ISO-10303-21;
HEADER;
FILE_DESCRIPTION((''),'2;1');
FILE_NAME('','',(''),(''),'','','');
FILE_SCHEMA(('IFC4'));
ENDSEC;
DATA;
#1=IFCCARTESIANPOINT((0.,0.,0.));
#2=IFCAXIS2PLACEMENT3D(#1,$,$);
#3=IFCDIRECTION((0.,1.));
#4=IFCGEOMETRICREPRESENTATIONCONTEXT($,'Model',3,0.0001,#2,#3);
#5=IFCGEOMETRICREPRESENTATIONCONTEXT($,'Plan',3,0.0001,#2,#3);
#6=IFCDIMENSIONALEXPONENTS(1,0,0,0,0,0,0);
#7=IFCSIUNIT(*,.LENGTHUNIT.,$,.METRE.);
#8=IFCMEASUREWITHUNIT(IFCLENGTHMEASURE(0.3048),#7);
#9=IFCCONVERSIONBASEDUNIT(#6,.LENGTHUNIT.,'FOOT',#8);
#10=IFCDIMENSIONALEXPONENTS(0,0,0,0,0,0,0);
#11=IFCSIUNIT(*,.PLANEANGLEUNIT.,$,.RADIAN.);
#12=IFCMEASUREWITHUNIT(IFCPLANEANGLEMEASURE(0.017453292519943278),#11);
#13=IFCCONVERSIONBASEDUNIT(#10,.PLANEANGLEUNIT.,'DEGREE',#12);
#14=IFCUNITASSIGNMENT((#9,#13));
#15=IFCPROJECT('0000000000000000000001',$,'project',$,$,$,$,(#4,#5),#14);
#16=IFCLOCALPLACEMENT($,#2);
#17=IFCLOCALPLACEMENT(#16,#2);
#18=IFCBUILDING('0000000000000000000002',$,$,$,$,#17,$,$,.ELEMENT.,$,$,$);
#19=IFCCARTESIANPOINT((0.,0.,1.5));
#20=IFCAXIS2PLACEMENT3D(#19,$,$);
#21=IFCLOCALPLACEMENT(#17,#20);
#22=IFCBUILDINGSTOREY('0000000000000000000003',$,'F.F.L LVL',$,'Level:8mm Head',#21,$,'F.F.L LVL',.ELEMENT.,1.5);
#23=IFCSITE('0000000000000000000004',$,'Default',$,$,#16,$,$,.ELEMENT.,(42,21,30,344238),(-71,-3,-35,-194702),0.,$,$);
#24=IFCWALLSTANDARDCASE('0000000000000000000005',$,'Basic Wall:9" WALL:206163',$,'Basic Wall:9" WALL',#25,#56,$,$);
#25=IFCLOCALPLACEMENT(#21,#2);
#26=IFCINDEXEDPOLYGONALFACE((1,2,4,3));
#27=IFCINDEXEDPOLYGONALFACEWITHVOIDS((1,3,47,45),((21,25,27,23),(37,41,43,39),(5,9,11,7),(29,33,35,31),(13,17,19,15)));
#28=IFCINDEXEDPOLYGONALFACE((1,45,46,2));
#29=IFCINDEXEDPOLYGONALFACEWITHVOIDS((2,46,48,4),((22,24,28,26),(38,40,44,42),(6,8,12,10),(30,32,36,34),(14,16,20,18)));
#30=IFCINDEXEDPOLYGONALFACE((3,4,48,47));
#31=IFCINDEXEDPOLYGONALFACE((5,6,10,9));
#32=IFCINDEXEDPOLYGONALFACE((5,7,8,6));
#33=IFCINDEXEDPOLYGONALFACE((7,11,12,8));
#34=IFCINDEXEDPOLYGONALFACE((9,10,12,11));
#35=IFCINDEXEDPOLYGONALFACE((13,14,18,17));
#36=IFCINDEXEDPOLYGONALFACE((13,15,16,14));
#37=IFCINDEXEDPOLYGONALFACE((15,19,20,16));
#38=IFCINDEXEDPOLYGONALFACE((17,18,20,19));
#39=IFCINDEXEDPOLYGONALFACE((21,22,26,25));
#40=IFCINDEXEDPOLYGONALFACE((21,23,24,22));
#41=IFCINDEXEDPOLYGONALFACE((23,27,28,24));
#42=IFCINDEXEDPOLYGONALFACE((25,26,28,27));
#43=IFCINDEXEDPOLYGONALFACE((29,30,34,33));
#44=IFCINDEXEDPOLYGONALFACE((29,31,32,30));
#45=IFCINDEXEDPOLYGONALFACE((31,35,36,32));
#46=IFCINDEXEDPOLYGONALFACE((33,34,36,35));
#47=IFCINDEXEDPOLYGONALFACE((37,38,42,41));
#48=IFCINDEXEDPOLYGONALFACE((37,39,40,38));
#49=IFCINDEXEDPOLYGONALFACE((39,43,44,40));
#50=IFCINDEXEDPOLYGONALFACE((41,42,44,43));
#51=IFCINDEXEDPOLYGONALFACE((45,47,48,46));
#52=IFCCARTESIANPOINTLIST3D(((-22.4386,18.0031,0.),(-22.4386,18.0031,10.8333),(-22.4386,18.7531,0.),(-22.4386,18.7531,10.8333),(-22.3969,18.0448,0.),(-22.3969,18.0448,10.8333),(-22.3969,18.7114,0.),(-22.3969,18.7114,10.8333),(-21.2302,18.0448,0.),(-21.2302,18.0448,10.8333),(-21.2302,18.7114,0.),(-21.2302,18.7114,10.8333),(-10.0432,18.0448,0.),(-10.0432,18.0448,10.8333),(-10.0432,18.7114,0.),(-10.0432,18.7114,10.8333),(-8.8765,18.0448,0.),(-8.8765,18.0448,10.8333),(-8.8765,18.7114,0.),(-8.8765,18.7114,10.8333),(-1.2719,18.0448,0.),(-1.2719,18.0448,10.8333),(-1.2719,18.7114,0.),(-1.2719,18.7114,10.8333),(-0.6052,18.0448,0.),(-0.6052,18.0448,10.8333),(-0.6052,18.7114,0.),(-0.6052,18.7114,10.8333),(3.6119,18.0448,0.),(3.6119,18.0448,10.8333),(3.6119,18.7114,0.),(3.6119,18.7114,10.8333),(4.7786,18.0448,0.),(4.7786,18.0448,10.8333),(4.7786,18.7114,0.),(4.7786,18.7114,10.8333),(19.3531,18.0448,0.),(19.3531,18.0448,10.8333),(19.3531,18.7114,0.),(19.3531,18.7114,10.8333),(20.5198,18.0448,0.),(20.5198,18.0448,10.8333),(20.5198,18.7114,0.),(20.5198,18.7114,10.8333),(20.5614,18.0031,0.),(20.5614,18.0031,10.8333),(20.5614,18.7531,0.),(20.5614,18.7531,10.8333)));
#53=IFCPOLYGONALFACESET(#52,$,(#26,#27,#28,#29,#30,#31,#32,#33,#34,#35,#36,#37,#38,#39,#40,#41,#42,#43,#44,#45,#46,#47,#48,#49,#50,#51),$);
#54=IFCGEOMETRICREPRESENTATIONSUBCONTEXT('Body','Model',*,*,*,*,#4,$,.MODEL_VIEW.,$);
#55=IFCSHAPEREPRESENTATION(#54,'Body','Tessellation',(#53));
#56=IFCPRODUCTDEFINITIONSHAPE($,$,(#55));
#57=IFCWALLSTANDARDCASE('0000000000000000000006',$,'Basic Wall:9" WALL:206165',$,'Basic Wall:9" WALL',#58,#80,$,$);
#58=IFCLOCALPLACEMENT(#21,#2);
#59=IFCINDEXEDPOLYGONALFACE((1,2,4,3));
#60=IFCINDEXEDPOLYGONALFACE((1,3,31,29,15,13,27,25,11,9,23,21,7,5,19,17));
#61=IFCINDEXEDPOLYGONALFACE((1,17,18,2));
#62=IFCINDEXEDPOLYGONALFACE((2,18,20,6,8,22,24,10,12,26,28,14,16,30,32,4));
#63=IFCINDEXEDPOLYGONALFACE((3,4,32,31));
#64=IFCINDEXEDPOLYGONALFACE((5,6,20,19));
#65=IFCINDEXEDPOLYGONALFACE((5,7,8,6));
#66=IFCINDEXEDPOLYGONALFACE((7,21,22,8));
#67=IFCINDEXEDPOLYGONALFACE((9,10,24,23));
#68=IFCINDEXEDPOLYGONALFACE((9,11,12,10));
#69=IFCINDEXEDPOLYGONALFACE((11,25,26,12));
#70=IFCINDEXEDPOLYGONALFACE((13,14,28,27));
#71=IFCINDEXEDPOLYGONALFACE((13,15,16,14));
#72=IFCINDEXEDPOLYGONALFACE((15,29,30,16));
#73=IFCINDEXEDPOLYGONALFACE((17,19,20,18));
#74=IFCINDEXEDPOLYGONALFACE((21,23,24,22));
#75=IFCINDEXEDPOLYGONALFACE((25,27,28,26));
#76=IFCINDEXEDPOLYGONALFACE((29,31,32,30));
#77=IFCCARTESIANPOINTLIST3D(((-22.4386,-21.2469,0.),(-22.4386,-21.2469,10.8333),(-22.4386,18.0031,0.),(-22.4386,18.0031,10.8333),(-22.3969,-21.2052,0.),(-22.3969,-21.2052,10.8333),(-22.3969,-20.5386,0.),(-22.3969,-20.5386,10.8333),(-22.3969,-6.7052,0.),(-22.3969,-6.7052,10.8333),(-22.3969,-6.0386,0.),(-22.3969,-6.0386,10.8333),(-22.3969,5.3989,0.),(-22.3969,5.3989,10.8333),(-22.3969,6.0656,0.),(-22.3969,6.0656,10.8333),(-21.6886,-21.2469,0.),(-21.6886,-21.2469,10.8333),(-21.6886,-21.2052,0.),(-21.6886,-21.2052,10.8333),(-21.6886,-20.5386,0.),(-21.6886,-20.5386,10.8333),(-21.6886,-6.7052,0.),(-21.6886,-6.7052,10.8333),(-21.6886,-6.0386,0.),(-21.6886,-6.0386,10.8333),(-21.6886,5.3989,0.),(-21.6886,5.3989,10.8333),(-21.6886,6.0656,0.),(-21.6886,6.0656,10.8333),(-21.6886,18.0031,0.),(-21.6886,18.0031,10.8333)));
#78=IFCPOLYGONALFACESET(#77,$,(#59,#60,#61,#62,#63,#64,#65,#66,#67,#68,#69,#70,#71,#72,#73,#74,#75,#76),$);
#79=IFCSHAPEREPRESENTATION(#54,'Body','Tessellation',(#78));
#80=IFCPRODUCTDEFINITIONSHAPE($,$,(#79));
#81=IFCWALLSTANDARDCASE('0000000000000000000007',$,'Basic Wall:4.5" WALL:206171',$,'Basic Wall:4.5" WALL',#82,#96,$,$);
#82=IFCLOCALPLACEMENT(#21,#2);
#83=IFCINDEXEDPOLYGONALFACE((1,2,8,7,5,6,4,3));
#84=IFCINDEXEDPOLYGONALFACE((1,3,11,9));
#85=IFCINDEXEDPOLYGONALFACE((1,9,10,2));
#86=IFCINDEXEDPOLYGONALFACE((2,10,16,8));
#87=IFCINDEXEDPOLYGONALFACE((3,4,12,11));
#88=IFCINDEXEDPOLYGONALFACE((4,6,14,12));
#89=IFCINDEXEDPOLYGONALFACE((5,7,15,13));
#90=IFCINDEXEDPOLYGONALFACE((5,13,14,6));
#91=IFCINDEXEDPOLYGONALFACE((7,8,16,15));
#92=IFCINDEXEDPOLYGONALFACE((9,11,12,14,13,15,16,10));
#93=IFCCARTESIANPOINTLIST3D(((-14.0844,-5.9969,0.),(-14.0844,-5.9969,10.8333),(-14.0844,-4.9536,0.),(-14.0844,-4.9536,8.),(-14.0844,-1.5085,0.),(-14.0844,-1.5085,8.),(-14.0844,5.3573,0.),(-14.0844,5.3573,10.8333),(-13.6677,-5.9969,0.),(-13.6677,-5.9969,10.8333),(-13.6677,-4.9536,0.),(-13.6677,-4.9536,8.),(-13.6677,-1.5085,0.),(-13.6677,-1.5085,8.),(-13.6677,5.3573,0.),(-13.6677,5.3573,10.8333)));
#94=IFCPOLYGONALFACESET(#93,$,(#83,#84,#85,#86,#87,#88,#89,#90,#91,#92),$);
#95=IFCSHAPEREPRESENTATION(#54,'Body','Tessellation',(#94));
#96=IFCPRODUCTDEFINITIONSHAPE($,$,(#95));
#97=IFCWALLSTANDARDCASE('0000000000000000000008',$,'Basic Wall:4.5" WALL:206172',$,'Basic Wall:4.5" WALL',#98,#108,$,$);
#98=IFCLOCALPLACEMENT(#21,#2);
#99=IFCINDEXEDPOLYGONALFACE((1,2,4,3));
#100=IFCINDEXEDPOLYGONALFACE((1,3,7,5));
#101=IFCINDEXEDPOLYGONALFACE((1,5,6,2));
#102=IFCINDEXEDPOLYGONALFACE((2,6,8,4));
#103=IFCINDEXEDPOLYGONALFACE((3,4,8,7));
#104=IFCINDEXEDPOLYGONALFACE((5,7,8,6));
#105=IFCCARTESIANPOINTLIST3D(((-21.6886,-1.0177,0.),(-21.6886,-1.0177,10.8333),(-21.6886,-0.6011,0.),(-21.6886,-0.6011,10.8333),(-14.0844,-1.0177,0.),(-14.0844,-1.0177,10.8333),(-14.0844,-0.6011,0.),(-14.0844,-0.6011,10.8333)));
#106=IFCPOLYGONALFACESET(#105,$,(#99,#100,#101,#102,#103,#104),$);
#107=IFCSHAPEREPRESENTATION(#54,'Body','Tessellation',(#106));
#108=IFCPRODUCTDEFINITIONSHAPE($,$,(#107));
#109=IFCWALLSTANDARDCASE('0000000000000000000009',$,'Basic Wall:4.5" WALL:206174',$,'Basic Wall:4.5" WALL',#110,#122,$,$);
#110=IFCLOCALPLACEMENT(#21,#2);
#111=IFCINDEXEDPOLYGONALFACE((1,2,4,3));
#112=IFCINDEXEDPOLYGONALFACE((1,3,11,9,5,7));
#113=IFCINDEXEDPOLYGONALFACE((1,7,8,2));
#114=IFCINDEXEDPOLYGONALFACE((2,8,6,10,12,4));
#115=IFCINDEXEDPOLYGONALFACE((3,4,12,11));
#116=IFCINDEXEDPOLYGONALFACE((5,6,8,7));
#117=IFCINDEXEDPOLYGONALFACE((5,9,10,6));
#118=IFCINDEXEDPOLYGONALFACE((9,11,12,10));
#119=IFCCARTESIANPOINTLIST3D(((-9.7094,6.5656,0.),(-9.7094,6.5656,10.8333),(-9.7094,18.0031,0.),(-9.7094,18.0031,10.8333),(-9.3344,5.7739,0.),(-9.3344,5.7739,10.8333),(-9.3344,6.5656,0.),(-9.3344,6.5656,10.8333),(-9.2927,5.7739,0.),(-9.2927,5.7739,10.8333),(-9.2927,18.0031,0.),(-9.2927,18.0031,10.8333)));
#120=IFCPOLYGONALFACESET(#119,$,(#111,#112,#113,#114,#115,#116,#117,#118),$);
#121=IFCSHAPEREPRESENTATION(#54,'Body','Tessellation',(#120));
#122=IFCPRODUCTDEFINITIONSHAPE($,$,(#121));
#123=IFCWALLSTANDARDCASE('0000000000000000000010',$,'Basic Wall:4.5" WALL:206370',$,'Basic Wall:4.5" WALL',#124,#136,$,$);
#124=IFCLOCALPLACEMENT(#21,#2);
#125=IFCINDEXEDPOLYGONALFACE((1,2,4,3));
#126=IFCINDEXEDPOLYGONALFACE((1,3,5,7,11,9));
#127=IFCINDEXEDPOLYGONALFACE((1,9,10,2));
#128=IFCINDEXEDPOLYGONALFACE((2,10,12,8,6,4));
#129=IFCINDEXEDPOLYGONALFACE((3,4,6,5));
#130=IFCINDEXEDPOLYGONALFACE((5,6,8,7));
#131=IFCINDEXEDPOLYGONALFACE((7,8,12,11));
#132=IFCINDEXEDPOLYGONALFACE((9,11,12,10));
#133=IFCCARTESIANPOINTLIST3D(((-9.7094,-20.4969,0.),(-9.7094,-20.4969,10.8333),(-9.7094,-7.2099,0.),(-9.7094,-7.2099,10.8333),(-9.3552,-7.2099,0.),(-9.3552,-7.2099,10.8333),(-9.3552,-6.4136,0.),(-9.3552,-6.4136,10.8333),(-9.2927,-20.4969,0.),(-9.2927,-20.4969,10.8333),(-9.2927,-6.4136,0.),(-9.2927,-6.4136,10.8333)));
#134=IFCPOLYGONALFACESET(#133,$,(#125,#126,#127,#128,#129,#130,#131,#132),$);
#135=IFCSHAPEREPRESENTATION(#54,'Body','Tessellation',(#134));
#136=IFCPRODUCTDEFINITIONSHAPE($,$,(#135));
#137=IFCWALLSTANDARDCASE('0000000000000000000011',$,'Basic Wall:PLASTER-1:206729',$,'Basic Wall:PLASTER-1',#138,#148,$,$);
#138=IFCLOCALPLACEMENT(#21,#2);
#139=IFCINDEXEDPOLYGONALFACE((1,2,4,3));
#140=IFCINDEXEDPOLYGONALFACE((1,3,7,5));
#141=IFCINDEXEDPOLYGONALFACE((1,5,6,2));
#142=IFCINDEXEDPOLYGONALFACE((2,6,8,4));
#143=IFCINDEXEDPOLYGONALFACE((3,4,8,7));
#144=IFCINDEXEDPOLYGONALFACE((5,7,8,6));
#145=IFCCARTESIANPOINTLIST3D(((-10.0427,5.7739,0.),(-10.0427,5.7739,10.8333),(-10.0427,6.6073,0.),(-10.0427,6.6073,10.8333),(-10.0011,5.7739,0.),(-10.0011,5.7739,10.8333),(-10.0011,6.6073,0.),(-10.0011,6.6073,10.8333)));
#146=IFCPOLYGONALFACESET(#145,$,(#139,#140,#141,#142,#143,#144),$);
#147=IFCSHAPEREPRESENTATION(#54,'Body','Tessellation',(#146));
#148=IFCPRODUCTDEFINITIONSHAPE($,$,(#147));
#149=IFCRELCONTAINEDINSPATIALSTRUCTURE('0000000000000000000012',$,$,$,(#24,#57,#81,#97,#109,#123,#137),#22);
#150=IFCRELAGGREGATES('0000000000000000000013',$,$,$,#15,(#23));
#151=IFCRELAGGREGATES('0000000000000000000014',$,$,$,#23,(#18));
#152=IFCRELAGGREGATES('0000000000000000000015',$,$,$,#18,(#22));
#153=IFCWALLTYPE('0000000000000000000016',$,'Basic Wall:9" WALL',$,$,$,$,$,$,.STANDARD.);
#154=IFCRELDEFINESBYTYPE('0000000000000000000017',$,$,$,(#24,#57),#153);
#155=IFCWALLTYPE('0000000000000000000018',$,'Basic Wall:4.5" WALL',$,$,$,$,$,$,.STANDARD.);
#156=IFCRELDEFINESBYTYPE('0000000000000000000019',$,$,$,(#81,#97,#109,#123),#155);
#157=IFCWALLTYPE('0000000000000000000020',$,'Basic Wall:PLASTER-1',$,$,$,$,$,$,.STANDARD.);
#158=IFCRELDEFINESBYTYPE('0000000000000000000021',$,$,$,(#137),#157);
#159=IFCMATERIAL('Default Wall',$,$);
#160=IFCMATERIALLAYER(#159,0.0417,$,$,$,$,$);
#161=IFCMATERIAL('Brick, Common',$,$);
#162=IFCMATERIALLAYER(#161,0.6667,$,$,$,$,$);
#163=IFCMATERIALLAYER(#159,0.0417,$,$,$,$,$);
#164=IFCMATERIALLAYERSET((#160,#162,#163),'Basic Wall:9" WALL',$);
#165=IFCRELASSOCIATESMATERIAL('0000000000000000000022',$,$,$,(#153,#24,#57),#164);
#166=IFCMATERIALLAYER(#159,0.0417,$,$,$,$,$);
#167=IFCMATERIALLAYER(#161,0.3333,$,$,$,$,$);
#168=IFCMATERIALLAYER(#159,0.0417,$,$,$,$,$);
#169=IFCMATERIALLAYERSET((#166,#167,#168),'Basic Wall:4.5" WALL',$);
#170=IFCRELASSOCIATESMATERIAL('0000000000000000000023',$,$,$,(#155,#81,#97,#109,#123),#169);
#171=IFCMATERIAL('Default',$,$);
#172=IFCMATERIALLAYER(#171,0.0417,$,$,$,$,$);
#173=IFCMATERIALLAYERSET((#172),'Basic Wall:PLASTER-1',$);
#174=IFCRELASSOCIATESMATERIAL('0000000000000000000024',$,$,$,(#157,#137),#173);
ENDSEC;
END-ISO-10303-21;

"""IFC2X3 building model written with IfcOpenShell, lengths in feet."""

from ifc_helpers import new_model, entity, si_unit, converted_unit, direction, frame, frame_2d, origin, origin_2d_with_axis, place, context, subcontext, project, spatial, polyline, rectangle, extrude, clip, bounded_halfspace, material, layer, layer_set, layer_usage, type_object, element, save


model = new_model("IFC2X3")

# Units and contexts
model_context = context("Model", 3, precision=0.0001, world=origin(), true_north=direction((0.0, 1.0)))
plan_context = context("Plan", 3, precision=0.0001, world=origin(), true_north=direction((0.0, 1.0)))
body_context = subcontext(model_context, "Body", "Model", "MODEL_VIEW")
ifc_project = project(units=[converted_unit("LENGTHUNIT", "FOOT", entity("IfcLengthMeasure", 0.3048), si_unit("LENGTHUNIT", "METRE"), dimensions=[1, 0, 0, 0, 0, 0, 0]), converted_unit("PLANEANGLEUNIT", "DEGREE", entity("IfcPlaneAngleMeasure", 0.017453292519943278), si_unit("PLANEANGLEUNIT", "RADIAN"), dimensions=[0, 0, 0, 0, 0, 0, 0])], contexts=[model_context, plan_context])

# Site, building, storey
site_placement = place(None, origin())
site = spatial("IfcSite", under=ifc_project, at=site_placement, Name="Default", CompositionType="ELEMENT", RefLatitude=(42, 21, 30, 344238), RefLongitude=(-71, -3, -35, -194702), RefElevation=0.0)
building_placement = place(site_placement, origin())
building = spatial("IfcBuilding", under=site, at=building_placement, CompositionType="ELEMENT")
storey_placement = place(building_placement, frame((0.0, 0.0, 1.5)))
storey = spatial("IfcBuildingStorey", under=building, at=storey_placement, Name="F.F.L LVL", ObjectType="Level:8mm Head", LongName="F.F.L LVL", CompositionType="ELEMENT", Elevation=1.5)

# Wall, openings
ifc_material_1 = material(Name="Default Wall")
ifc_layer_1 = layer(ifc_material_1, 0.0417)
ifc_material_2 = material(Name="Brick, Common")
ifc_layer_2 = layer(ifc_material_2, 0.6667)
ifc_layer_3 = layer(ifc_material_1, 0.0417)
ifc_layer_set_1 = layer_set([ifc_layer_1, ifc_layer_2, ifc_layer_3], Name="Basic Wall:9\" WALL")
ifc_layer_usage_1 = layer_usage(ifc_layer_set_1, "AXIS2", "NEGATIVE", 0.375)
wall_type_1 = type_object("IfcWallType", Name="Basic Wall:9\" WALL", PredefinedType="STANDARD", material=ifc_layer_set_1)
wall_1_placement = place(storey_placement, frame((-22.4386, 18.3781, 0.0)))
wall_1 = element("IfcWallStandardCase", 1, at=wall_1_placement, inside=storey, type_object=wall_type_1, material=ifc_layer_usage_1, Name="Basic Wall:9\" WALL:206163", ObjectType="Basic Wall:9\" WALL", context=body_context, shape_type="SweptSolid", body=[
    extrude(rectangle(XDim=43.0, YDim=0.75, at=frame_2d((21.5, 0.0), x_axis=(-1.0, 0.0))), origin(), (0.0, 0.0, 1.0), 10.8333),
])
opening_1_placement = place(storey_placement, frame((-22.4386, 18.3781, 0.0)))
element("IfcOpeningElement", 2, at=opening_1_placement, cuts=wall_1, ObjectType="Opening", context=body_context, shape_type="SweptSolid", body=[
    extrude(rectangle(XDim=10.8333, YDim=0.6667, at=frame_2d((0.0, 0.0), x_axis=(1.0, 0.0))), frame((41.7917, 0.0, 5.4167), z_axis=(1.0, 0.0, 0.0), x_axis=(0.0, 0.0, -1.0)), (0.0, 0.0, 1.0), 1.1667),
])
opening_2_placement = place(storey_placement, frame((-22.4386, 18.3781, 0.0)))
element("IfcOpeningElement", 3, at=opening_2_placement, cuts=wall_1, ObjectType="Opening", context=body_context, shape_type="SweptSolid", body=[
    extrude(rectangle(XDim=10.8333, YDim=0.6667, at=origin_2d_with_axis()), frame((21.1667, 0.0, 5.4167), z_axis=(1.0, 0.0, 0.0), x_axis=(0.0, 0.0, 1.0)), (0.0, 0.0, 1.0), 0.6667),
])
opening_3_placement = place(storey_placement, frame((-22.4386, 18.3781, 0.0)))
element("IfcOpeningElement", 4, at=opening_3_placement, cuts=wall_1, ObjectType="Opening", context=body_context, shape_type="SweptSolid", body=[
    extrude(rectangle(XDim=10.8333, YDim=0.6667, at=origin_2d_with_axis()), frame((26.0505, 0.0, 5.4167), z_axis=(1.0, 0.0, 0.0), x_axis=(0.0, 0.0, -1.0)), (0.0, 0.0, 1.0), 1.1667),
])
opening_4_placement = place(storey_placement, frame((-22.4386, 18.3781, 0.0)))
element("IfcOpeningElement", 5, at=opening_4_placement, cuts=wall_1, ObjectType="Opening", context=body_context, shape_type="SweptSolid", body=[
    extrude(rectangle(XDim=10.8333, YDim=0.6667, at=origin_2d_with_axis()), frame((12.3954, 0.0, 5.4167), z_axis=(1.0, 0.0, 0.0), x_axis=(0.0, 0.0, -1.0)), (0.0, 0.0, 1.0), 1.1667),
])
opening_5_placement = place(storey_placement, frame((-22.4386, 18.3781, 0.0)))
element("IfcOpeningElement", 6, at=opening_5_placement, cuts=wall_1, ObjectType="Opening", context=body_context, shape_type="SweptSolid", body=[
    extrude(rectangle(XDim=10.8333, YDim=0.6667, at=origin_2d_with_axis()), frame((0.0417, 0.0, 5.4167), z_axis=(1.0, 0.0, 0.0), x_axis=(0.0, 0.0, -1.0)), (0.0, 0.0, 1.0), 1.1667),
])

# Wall
ifc_layer_usage_2 = layer_usage(ifc_layer_set_1, "AXIS2", "NEGATIVE", 0.375)
wall_2_placement = place(storey_placement, frame((-22.0636, 18.0031, 0.0), z_axis=(0.0, 0.0, 1.0), x_axis=(0.0, -1.0, 0.0)))
element("IfcWallStandardCase", 7, at=wall_2_placement, inside=storey, type_object=wall_type_1, material=ifc_layer_usage_2, Name="Basic Wall:9\" WALL:206165", ObjectType="Basic Wall:9\" WALL", context=body_context, shape_type="Clipping", body=[
    clip(clip(clip(extrude(rectangle(XDim=39.25, YDim=0.75, at=frame_2d((19.625, 0.0), x_axis=(-1.0, 0.0))), origin(), (0.0, 0.0, 1.0), 10.8333), bounded_halfspace(frame((39.2083, -0.3333, 10.8333), z_axis=(0.0, -1.0, 0.0), x_axis=(0.0, 0.0, -1.0)), True, frame((39.2083, -0.3333, 10.8333), z_axis=(0.0, -1.0, 0.0), x_axis=(0.0, 0.0, -1.0)), polyline([(0.0, 0.0), (0.0, -0.6667), (10.8333, -0.6667), (10.8333, 0.0), (0.0, 0.0)]))), bounded_halfspace(frame((24.7083, -0.3333, 10.8333), z_axis=(0.0, -1.0, 0.0), x_axis=(0.0, 0.0, -1.0)), True, frame((24.7083, -0.3333, 10.8333), z_axis=(0.0, -1.0, 0.0), x_axis=(0.0, 0.0, -1.0)), polyline([(0.0, 0.0), (0.0, -0.6667), (10.8333, -0.6667), (10.8333, 0.0), (0.0, 0.0)]))), bounded_halfspace(frame((12.6042, -0.3333, 10.8333), z_axis=(0.0, -1.0, 0.0), x_axis=(0.0, 0.0, -1.0)), True, frame((12.6042, -0.3333, 10.8333), z_axis=(0.0, -1.0, 0.0), x_axis=(0.0, 0.0, -1.0)), polyline([(0.0, 0.0), (0.0, -0.6667), (10.8333, -0.6667), (10.8333, 0.0), (0.0, 0.0)]))),
])

# Wall, opening
ifc_layer_4 = layer(ifc_material_1, 0.0417)
ifc_layer_5 = layer(ifc_material_2, 0.3333)
ifc_layer_6 = layer(ifc_material_1, 0.0417)
ifc_layer_set_2 = layer_set([ifc_layer_4, ifc_layer_5, ifc_layer_6], Name="Basic Wall:4.5\" WALL")
ifc_layer_usage_3 = layer_usage(ifc_layer_set_2, "AXIS2", "NEGATIVE", 0.2083)
wall_type_2 = type_object("IfcWallType", Name="Basic Wall:4.5\" WALL", PredefinedType="STANDARD", material=ifc_layer_set_2)
wall_3_placement = place(storey_placement, frame((-13.8761, 5.3573, 0.0), z_axis=(0.0, 0.0, 1.0), x_axis=(0.0, -1.0, 0.0)))
wall_3 = element("IfcWallStandardCase", 8, at=wall_3_placement, inside=storey, type_object=wall_type_2, material=ifc_layer_usage_3, Name="Basic Wall:4.5\" WALL:206171", ObjectType="Basic Wall:4.5\" WALL", context=body_context, shape_type="SweptSolid", body=[
    extrude(rectangle(XDim=11.3542, YDim=0.4167, at=frame_2d((5.6771, 0.0), x_axis=(-1.0, 0.0))), origin(), (0.0, 0.0, 1.0), 10.8333),
])
opening_6_placement = place(wall_3_placement, origin())
element("IfcOpeningElement", 9, at=opening_6_placement, cuts=wall_3, ObjectType="Opening", context=body_context, shape_type="SweptSolid", body=[
    extrude(rectangle(XDim=8.0, YDim=3.4451, at=origin_2d_with_axis()), frame((8.5884, -0.2083, 4.0), z_axis=(0.0, 1.0, 0.0), x_axis=(0.0, 0.0, -1.0)), (0.0, 0.0, 1.0), 0.4167),
])

# Wall
ifc_layer_usage_4 = layer_usage(ifc_layer_set_2, "AXIS2", "NEGATIVE", 0.2083)
wall_4_placement = place(storey_placement, frame((-14.0844, -0.8094, 0.0), z_axis=(0.0, 0.0, 1.0), x_axis=(-1.0, 0.0, 0.0)))
element("IfcWallStandardCase", 10, at=wall_4_placement, inside=storey, type_object=wall_type_2, material=ifc_layer_usage_4, Name="Basic Wall:4.5\" WALL:206172", ObjectType="Basic Wall:4.5\" WALL", context=body_context, shape_type="SweptSolid", body=[
    extrude(rectangle(XDim=7.6042, YDim=0.4167, at=frame_2d((3.8021, 0.0), x_axis=(-1.0, 0.0))), origin(), (0.0, 0.0, 1.0), 10.8333),
])

# Walls
ifc_layer_usage_5 = layer_usage(ifc_layer_set_2, "AXIS2", "NEGATIVE", 0.2083)
wall_5_placement = place(storey_placement, frame((-9.5011, 18.0031, 0.0), z_axis=(0.0, 0.0, 1.0), x_axis=(0.0, -1.0, 0.0)))
element("IfcWallStandardCase", 11, at=wall_5_placement, inside=storey, type_object=wall_type_2, material=ifc_layer_usage_5, Name="Basic Wall:4.5\" WALL:206174", ObjectType="Basic Wall:4.5\" WALL", context=body_context, shape_type="Clipping", body=[
    clip(clip(extrude(rectangle(XDim=12.2292, YDim=0.4167, at=frame_2d((6.1146, 0.0), x_axis=(-1.0, 0.0))), origin(), (0.0, 0.0, 1.0), 10.8333), bounded_halfspace(frame((11.4375, 0.1667, 0.0), z_axis=(-1.0, 0.0, 0.0), x_axis=(0.0, 0.0, -1.0)), True, frame((11.4375, 0.1667, 0.0), z_axis=(-1.0, 0.0, 0.0), x_axis=(0.0, 0.0, -1.0)), polyline([(0.0, 0.0), (0.0, 0.375), (-10.8333, 0.375), (-10.8333, 0.0), (0.0, 0.0)]))), bounded_halfspace(frame((11.4375, 0.1667, 10.8333), z_axis=(0.0, 1.0, 0.0), x_axis=(0.0, 0.0, -1.0)), True, frame((11.4375, 0.1667, 10.8333), z_axis=(0.0, 1.0, 0.0), x_axis=(0.0, 0.0, -1.0)), polyline([(0.0, 0.0), (0.0, -0.7917), (10.8333, -0.7917), (10.8333, 0.0), (0.0, 0.0)]))),
])
ifc_layer_usage_6 = layer_usage(ifc_layer_set_2, "AXIS2", "NEGATIVE", 0.2083)
wall_6_placement = place(storey_placement, frame((-9.5011, -20.4969, 0.0), z_axis=(0.0, 0.0, 1.0), x_axis=(0.0, 1.0, 0.0)))
element("IfcWallStandardCase", 12, at=wall_6_placement, inside=storey, type_object=wall_type_2, material=ifc_layer_usage_6, Name="Basic Wall:4.5\" WALL:206370", ObjectType="Basic Wall:4.5\" WALL", context=body_context, shape_type="Clipping", body=[
    clip(clip(extrude(rectangle(XDim=14.0833, YDim=0.4167, at=frame_2d((7.0417, 0.0), x_axis=(-1.0, 0.0))), origin(), (0.0, 0.0, 1.0), 10.8333), bounded_halfspace(frame((13.287, -0.1458, 0.0), z_axis=(0.0, -1.0, 0.0), x_axis=(0.0, 0.0, -1.0)), True, frame((13.287, -0.1458, 0.0), z_axis=(0.0, -1.0, 0.0), x_axis=(0.0, 0.0, -1.0)), polyline([(0.0, 0.0), (0.0, 0.7963), (-10.8333, 0.7963), (-10.8333, 0.0), (0.0, 0.0)]))), bounded_halfspace(frame((13.287, -0.1458, 10.8333), z_axis=(-1.0, 0.0, 0.0), x_axis=(0.0, 0.0, -1.0)), True, frame((13.287, -0.1458, 10.8333), z_axis=(-1.0, 0.0, 0.0), x_axis=(0.0, 0.0, -1.0)), polyline([(0.0, 0.0), (0.0, -0.3542), (10.8333, -0.3542), (10.8333, 0.0), (0.0, 0.0)]))),
])
ifc_material_3 = material(Name="Default")
ifc_layer_7 = layer(ifc_material_3, 0.0417)
ifc_layer_set_3 = layer_set([ifc_layer_7], Name="Basic Wall:PLASTER-1")
ifc_layer_usage_7 = layer_usage(ifc_layer_set_3, "AXIS2", "NEGATIVE", 0.0208)
wall_type_3 = type_object("IfcWallType", Name="Basic Wall:PLASTER-1", PredefinedType="STANDARD", material=ifc_layer_set_3)
wall_7_placement = place(storey_placement, frame((-10.0219, 5.7739, 0.0), z_axis=(0.0, 0.0, 1.0), x_axis=(0.0, 1.0, 0.0)))
element("IfcWallStandardCase", 13, at=wall_7_placement, inside=storey, type_object=wall_type_3, material=ifc_layer_usage_7, Name="Basic Wall:PLASTER-1:206729", ObjectType="Basic Wall:PLASTER-1", context=body_context, shape_type="SweptSolid", body=[
    extrude(rectangle(XDim=0.8333, YDim=0.0417, at=frame_2d((0.4167, 0.0), x_axis=(-1.0, 0.0))), origin(), (0.0, 0.0, 1.0), 10.8333),
])

save(model, "model.ifc")
